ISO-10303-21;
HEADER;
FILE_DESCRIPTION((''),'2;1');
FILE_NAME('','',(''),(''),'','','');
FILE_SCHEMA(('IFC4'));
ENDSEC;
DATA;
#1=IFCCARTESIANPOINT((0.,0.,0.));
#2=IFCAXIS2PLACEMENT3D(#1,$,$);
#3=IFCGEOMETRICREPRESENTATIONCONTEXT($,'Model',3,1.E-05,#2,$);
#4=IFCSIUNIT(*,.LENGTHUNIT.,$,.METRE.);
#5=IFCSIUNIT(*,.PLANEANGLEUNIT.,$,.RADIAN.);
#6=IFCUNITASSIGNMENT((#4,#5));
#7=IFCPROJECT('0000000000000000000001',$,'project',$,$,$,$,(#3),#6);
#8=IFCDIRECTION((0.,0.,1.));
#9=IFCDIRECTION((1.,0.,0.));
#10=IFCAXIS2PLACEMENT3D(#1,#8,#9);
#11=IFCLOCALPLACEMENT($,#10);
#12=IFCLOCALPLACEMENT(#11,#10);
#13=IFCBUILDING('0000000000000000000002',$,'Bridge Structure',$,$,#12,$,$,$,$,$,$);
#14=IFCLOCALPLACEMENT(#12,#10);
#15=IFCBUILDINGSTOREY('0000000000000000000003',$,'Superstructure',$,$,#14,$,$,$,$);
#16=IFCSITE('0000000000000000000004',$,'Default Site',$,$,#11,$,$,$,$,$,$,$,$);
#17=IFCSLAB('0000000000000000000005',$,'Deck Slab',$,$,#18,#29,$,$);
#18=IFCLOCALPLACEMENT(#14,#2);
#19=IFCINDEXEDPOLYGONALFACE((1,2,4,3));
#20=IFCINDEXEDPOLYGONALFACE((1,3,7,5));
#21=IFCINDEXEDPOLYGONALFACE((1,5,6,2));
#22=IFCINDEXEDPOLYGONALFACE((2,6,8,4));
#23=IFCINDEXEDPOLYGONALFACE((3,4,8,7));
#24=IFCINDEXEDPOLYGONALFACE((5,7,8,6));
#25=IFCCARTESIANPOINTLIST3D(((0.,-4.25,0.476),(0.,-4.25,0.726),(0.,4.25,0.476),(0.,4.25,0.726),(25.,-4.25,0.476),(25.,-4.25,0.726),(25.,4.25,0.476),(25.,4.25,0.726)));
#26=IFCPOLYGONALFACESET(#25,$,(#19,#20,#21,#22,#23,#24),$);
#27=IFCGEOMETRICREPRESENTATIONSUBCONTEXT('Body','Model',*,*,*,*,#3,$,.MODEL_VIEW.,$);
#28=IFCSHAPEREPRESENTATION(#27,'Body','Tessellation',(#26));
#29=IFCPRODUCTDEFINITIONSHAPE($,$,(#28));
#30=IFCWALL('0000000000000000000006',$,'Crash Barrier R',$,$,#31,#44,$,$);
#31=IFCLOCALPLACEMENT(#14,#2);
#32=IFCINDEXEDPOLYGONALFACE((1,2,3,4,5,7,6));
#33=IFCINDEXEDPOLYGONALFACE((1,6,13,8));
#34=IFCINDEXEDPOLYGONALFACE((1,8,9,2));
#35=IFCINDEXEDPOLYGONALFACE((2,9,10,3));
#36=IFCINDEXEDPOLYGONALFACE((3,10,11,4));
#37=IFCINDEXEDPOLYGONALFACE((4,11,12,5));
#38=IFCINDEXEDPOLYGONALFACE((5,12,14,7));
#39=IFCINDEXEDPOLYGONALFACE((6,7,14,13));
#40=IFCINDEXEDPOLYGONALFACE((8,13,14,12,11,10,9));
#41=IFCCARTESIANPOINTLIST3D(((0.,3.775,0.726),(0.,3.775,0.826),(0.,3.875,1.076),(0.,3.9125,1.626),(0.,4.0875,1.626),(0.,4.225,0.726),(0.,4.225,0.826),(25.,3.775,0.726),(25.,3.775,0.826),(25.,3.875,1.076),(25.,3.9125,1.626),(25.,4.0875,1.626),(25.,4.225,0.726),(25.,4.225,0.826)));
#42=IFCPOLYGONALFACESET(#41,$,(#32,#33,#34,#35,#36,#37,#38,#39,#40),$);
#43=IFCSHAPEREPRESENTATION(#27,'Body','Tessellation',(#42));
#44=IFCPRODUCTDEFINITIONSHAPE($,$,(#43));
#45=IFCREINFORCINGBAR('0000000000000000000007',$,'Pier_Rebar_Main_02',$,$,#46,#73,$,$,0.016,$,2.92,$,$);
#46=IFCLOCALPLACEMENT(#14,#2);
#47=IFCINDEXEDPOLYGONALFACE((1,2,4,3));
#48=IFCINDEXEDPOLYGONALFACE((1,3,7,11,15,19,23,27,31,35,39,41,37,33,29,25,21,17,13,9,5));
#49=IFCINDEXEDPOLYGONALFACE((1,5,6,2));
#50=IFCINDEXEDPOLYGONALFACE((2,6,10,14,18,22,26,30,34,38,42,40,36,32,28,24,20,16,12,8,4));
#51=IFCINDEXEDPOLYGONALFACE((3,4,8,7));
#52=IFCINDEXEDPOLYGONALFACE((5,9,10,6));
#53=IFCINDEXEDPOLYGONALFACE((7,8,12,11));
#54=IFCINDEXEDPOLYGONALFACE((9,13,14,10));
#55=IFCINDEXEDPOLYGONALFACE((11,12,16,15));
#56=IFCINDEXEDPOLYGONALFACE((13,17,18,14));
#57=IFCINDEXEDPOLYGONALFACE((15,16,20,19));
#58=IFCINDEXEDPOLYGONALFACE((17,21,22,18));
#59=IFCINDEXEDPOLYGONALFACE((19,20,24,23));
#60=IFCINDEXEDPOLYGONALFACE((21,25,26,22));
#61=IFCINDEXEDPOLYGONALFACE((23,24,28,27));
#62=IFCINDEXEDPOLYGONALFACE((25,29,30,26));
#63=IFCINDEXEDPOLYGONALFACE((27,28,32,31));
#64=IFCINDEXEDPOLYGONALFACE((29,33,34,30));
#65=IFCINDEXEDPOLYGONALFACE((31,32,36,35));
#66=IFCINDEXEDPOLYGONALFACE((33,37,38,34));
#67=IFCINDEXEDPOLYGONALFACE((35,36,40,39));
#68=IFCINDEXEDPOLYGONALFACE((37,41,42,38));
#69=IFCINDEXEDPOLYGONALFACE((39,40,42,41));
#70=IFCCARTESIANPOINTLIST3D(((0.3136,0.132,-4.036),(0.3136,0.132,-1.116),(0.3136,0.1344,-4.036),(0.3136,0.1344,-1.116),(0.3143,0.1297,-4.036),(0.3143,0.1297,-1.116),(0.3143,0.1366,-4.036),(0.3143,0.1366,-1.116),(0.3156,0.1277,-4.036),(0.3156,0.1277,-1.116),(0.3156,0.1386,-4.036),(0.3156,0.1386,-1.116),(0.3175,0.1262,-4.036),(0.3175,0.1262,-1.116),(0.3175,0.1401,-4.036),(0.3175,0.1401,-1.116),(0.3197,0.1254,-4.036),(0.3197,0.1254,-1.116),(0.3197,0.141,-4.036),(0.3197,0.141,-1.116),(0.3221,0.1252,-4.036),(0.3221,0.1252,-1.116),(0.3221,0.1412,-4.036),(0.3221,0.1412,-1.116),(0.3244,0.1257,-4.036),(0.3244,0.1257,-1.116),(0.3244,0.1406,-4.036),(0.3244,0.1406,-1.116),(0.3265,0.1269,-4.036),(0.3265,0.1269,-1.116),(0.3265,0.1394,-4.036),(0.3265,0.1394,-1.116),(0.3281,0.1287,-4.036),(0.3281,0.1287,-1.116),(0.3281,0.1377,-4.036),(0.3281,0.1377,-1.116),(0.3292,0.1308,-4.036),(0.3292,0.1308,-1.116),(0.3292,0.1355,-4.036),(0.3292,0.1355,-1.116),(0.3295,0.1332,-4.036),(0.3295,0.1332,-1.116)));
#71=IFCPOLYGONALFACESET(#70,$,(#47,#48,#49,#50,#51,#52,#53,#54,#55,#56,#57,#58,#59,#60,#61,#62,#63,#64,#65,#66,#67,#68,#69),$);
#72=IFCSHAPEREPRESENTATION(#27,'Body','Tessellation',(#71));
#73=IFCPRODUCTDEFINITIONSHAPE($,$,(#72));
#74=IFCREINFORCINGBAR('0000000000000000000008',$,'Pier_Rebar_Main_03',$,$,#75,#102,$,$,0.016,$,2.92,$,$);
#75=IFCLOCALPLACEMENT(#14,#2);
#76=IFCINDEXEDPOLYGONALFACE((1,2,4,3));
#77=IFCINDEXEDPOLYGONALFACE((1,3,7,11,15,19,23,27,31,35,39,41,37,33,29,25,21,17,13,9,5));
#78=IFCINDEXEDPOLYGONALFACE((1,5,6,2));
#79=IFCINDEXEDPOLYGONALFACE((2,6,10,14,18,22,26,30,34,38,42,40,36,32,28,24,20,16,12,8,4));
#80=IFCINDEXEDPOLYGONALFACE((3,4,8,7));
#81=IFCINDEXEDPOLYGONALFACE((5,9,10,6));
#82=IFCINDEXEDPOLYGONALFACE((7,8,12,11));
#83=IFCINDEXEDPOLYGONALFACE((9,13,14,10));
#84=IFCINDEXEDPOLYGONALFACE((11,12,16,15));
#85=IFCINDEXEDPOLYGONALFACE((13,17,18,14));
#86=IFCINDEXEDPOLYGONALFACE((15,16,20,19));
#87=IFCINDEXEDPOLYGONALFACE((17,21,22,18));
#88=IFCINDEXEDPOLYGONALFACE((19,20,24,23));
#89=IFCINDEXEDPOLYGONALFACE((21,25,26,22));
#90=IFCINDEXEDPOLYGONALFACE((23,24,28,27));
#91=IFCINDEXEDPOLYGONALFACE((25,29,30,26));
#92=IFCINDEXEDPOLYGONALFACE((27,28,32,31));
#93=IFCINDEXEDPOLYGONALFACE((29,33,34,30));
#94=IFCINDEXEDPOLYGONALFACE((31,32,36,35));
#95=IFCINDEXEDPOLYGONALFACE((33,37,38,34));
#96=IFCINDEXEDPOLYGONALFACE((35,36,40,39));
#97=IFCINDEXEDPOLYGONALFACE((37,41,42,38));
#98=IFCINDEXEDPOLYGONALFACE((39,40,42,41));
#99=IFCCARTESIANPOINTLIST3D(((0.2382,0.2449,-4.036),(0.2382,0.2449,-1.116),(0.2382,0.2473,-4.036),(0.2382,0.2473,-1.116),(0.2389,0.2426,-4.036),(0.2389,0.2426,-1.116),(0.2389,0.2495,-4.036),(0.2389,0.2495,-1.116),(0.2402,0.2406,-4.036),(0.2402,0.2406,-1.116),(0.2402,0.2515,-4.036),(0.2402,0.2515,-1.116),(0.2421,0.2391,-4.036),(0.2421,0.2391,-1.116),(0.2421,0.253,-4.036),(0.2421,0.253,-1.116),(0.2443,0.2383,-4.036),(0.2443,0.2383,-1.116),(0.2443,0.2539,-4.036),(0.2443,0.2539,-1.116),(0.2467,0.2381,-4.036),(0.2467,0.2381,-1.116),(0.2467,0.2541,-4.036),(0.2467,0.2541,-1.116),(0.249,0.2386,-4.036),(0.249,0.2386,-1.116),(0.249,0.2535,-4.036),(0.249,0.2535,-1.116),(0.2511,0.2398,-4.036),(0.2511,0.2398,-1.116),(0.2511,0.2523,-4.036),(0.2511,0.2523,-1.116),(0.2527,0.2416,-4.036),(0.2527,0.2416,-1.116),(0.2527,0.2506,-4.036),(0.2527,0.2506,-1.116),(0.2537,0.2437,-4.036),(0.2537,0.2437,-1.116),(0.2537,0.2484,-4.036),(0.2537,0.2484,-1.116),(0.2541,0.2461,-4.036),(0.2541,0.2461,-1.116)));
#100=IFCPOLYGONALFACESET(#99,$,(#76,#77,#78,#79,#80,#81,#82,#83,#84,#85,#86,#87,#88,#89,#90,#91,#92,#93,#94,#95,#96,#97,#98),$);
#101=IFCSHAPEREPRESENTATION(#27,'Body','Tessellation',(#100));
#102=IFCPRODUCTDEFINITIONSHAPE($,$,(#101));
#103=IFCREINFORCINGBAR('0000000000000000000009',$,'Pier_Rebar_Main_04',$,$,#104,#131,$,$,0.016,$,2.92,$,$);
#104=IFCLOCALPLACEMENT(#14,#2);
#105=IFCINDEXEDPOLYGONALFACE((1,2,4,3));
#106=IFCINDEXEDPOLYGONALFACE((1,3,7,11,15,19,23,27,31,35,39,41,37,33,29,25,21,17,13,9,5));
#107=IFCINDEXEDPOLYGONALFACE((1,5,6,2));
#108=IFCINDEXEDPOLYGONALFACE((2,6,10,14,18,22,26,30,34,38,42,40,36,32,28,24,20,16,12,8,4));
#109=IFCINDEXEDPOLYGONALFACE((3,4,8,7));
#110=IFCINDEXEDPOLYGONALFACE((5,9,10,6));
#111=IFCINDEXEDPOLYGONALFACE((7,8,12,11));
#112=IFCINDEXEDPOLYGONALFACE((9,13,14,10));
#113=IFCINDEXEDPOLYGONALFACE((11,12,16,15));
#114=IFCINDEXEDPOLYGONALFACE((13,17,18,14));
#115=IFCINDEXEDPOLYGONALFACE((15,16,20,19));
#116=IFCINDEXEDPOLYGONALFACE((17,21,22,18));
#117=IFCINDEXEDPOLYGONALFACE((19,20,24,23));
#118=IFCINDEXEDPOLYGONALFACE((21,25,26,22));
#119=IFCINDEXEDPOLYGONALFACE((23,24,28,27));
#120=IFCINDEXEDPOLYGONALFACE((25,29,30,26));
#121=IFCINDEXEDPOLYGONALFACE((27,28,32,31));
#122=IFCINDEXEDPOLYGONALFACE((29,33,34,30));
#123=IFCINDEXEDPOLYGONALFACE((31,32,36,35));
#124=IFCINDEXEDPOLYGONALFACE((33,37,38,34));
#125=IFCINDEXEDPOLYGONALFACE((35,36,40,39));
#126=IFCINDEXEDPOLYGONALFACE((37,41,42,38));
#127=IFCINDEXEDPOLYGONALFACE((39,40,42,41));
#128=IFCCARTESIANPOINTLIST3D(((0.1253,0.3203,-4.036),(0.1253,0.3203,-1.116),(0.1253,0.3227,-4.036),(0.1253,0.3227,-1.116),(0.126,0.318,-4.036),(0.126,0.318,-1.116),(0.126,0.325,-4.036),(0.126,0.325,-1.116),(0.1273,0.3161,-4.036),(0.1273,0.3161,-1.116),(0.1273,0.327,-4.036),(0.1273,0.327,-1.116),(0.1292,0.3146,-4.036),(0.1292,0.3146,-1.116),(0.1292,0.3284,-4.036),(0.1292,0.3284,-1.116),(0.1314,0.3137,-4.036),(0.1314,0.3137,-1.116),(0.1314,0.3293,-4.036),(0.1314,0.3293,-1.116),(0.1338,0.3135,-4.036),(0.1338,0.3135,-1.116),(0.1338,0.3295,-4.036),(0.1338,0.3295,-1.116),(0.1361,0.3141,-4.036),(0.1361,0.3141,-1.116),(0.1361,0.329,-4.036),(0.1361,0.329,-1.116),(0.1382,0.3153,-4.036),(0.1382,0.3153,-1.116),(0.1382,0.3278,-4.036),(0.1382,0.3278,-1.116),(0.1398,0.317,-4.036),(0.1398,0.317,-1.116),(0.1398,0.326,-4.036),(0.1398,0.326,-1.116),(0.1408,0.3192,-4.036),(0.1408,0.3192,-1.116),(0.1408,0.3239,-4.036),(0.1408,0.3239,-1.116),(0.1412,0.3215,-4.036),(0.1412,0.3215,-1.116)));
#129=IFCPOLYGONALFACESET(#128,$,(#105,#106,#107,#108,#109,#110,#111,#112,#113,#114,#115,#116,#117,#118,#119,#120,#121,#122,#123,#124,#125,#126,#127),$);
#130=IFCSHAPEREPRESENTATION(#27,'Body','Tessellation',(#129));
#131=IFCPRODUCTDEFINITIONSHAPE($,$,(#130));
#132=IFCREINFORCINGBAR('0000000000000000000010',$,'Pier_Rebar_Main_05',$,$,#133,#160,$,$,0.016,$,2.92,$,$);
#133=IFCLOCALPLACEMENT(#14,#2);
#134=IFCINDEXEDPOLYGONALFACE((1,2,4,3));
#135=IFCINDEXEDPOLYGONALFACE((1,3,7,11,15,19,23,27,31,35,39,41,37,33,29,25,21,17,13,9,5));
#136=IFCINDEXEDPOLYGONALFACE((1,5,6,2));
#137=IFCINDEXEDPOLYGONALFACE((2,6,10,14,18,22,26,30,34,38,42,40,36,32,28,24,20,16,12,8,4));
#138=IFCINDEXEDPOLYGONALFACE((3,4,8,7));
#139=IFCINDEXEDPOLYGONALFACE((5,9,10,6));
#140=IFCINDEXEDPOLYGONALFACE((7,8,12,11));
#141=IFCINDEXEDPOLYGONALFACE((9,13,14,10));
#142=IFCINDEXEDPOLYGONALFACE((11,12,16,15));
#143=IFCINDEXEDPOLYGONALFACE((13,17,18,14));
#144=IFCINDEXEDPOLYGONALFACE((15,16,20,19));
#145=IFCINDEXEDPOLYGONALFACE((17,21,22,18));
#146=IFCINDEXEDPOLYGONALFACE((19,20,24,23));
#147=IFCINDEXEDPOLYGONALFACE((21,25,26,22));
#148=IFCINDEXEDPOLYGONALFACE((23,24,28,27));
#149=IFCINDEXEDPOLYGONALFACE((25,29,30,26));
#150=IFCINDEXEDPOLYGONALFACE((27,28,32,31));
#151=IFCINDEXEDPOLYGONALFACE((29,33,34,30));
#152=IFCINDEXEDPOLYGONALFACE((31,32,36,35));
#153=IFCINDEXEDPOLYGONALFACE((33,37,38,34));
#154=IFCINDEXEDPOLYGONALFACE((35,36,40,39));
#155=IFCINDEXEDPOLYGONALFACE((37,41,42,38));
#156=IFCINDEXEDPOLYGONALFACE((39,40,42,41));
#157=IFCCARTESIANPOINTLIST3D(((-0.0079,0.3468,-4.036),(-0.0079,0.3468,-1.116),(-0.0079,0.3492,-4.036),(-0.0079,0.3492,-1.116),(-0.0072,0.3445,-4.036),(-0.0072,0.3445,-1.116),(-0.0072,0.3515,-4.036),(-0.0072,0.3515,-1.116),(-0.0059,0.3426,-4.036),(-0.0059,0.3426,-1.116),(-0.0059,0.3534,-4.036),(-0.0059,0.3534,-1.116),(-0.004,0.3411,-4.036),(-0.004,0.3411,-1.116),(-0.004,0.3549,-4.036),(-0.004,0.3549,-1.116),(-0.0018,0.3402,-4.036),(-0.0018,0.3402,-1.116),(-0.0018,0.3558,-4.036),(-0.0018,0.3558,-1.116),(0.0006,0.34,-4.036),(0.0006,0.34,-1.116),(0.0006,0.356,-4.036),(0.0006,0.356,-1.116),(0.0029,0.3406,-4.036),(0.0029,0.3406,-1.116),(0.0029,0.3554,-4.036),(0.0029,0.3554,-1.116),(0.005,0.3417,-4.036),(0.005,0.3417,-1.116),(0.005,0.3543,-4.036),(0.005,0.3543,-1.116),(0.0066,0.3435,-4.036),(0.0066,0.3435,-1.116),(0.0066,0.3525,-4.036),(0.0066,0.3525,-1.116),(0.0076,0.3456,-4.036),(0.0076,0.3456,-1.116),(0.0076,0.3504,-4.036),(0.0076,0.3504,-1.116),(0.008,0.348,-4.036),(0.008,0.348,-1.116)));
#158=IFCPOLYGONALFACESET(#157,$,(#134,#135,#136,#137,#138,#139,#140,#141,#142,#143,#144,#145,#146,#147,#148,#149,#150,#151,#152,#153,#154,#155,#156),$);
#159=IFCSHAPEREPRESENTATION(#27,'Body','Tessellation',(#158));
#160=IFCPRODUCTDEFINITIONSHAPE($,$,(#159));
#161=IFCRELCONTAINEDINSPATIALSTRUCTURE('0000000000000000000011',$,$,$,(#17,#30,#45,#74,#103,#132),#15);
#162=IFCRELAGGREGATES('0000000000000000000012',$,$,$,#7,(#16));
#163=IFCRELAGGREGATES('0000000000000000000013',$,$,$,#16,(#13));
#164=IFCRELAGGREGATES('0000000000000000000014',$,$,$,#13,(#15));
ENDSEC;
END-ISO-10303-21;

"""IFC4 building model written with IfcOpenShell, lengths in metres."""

from ifc_helpers import new_model, si_unit, frame, origin, origin_with_axes, origin_2d_with_axis, place, context, subcontext, project, spatial, polyline, circle, outline, extrude, element, save


model = new_model("IFC4")

# Units and contexts
model_context = context("Model", 3, precision=1e-05, world=origin())
body_context = subcontext(model_context, "Body", "Model", "MODEL_VIEW")
ifc_project = project(units=[si_unit("LENGTHUNIT", "METRE"), si_unit("PLANEANGLEUNIT", "RADIAN")], contexts=[model_context])

# Site, building, storey
site_placement = place(None, origin_with_axes())
site = spatial("IfcSite", under=ifc_project, at=site_placement, Name="Default Site")
building_placement = place(site_placement, origin_with_axes())
building = spatial("IfcBuilding", under=site, at=building_placement, Name="Bridge Structure")
storey_placement = place(building_placement, origin_with_axes())
storey = spatial("IfcBuildingStorey", under=building, at=storey_placement, Name="Superstructure")

# Slab
slab_placement = place(storey_placement, frame((0.0, 0.0, 0.476), z_axis=(0.0, 0.0, 1.0), x_axis=(1.0, 0.0, 0.0)))
element("IfcSlab", 1, at=slab_placement, inside=storey, Name="Deck Slab", context=body_context, shape_type="SweptSolid", body=[
    extrude(outline(polyline([(0.0, -4.25), (25.0, -4.25), (25.0, 4.25), (0.0, 4.25), (0.0, -4.25)])), origin_with_axes(), (0.0, 0.0, 1.0), 0.25),
])

# Wall
wall_placement = place(storey_placement, frame((0.0, 3.775, 0.726), z_axis=(1.0, 0.0, 0.0), x_axis=(0.0, 1.0, 0.0)))
element("IfcWall", 2, at=wall_placement, inside=storey, Name="Crash Barrier R", context=body_context, shape_type="SweptSolid", body=[
    extrude(outline(polyline([(0.45, 0.0), (0.0, 0.0), (0.0, 0.1), (0.1, 0.35), (0.1375, 0.9), (0.3125, 0.9), (0.45, 0.1), (0.45, 0.0)])), origin_with_axes(), (0.0, 0.0, 1.0), 25.0),
])

# Reinforcing bars
for number, where, z_axis, x_axis, name in (
    (3, (0.3215, 0.1332, -4.036), (0.0, 0.0, 1.0), (1.0, 0.0, 0.0), "Pier_Rebar_Main_02"),
    (4, (0.2461, 0.2461, -4.036), (0.0, 0.0, 1.0), (1.0, 0.0, 0.0), "Pier_Rebar_Main_03"),
    (5, (0.1332, 0.3215, -4.036), (0.0, 0.0, 1.0), (1.0, 0.0, 0.0), "Pier_Rebar_Main_04"),
    (6, (0.0, 0.348, -4.036), (0.0, 0.0, 1.0), (1.0, 0.0, 0.0), "Pier_Rebar_Main_05"),
):
    element("IfcReinforcingBar", number, at=place(storey_placement, frame(where, z_axis=z_axis, x_axis=x_axis)), inside=storey, Name=name, BarLength=2.92, NominalDiameter=0.016, context=body_context, shape_type="SweptSolid", body=[
        extrude(circle(Radius=0.008, at=origin_2d_with_axis()), origin_with_axes(), (0.0, 0.0, 1.0), 2.92),
    ])

save(model, "model.ifc")
